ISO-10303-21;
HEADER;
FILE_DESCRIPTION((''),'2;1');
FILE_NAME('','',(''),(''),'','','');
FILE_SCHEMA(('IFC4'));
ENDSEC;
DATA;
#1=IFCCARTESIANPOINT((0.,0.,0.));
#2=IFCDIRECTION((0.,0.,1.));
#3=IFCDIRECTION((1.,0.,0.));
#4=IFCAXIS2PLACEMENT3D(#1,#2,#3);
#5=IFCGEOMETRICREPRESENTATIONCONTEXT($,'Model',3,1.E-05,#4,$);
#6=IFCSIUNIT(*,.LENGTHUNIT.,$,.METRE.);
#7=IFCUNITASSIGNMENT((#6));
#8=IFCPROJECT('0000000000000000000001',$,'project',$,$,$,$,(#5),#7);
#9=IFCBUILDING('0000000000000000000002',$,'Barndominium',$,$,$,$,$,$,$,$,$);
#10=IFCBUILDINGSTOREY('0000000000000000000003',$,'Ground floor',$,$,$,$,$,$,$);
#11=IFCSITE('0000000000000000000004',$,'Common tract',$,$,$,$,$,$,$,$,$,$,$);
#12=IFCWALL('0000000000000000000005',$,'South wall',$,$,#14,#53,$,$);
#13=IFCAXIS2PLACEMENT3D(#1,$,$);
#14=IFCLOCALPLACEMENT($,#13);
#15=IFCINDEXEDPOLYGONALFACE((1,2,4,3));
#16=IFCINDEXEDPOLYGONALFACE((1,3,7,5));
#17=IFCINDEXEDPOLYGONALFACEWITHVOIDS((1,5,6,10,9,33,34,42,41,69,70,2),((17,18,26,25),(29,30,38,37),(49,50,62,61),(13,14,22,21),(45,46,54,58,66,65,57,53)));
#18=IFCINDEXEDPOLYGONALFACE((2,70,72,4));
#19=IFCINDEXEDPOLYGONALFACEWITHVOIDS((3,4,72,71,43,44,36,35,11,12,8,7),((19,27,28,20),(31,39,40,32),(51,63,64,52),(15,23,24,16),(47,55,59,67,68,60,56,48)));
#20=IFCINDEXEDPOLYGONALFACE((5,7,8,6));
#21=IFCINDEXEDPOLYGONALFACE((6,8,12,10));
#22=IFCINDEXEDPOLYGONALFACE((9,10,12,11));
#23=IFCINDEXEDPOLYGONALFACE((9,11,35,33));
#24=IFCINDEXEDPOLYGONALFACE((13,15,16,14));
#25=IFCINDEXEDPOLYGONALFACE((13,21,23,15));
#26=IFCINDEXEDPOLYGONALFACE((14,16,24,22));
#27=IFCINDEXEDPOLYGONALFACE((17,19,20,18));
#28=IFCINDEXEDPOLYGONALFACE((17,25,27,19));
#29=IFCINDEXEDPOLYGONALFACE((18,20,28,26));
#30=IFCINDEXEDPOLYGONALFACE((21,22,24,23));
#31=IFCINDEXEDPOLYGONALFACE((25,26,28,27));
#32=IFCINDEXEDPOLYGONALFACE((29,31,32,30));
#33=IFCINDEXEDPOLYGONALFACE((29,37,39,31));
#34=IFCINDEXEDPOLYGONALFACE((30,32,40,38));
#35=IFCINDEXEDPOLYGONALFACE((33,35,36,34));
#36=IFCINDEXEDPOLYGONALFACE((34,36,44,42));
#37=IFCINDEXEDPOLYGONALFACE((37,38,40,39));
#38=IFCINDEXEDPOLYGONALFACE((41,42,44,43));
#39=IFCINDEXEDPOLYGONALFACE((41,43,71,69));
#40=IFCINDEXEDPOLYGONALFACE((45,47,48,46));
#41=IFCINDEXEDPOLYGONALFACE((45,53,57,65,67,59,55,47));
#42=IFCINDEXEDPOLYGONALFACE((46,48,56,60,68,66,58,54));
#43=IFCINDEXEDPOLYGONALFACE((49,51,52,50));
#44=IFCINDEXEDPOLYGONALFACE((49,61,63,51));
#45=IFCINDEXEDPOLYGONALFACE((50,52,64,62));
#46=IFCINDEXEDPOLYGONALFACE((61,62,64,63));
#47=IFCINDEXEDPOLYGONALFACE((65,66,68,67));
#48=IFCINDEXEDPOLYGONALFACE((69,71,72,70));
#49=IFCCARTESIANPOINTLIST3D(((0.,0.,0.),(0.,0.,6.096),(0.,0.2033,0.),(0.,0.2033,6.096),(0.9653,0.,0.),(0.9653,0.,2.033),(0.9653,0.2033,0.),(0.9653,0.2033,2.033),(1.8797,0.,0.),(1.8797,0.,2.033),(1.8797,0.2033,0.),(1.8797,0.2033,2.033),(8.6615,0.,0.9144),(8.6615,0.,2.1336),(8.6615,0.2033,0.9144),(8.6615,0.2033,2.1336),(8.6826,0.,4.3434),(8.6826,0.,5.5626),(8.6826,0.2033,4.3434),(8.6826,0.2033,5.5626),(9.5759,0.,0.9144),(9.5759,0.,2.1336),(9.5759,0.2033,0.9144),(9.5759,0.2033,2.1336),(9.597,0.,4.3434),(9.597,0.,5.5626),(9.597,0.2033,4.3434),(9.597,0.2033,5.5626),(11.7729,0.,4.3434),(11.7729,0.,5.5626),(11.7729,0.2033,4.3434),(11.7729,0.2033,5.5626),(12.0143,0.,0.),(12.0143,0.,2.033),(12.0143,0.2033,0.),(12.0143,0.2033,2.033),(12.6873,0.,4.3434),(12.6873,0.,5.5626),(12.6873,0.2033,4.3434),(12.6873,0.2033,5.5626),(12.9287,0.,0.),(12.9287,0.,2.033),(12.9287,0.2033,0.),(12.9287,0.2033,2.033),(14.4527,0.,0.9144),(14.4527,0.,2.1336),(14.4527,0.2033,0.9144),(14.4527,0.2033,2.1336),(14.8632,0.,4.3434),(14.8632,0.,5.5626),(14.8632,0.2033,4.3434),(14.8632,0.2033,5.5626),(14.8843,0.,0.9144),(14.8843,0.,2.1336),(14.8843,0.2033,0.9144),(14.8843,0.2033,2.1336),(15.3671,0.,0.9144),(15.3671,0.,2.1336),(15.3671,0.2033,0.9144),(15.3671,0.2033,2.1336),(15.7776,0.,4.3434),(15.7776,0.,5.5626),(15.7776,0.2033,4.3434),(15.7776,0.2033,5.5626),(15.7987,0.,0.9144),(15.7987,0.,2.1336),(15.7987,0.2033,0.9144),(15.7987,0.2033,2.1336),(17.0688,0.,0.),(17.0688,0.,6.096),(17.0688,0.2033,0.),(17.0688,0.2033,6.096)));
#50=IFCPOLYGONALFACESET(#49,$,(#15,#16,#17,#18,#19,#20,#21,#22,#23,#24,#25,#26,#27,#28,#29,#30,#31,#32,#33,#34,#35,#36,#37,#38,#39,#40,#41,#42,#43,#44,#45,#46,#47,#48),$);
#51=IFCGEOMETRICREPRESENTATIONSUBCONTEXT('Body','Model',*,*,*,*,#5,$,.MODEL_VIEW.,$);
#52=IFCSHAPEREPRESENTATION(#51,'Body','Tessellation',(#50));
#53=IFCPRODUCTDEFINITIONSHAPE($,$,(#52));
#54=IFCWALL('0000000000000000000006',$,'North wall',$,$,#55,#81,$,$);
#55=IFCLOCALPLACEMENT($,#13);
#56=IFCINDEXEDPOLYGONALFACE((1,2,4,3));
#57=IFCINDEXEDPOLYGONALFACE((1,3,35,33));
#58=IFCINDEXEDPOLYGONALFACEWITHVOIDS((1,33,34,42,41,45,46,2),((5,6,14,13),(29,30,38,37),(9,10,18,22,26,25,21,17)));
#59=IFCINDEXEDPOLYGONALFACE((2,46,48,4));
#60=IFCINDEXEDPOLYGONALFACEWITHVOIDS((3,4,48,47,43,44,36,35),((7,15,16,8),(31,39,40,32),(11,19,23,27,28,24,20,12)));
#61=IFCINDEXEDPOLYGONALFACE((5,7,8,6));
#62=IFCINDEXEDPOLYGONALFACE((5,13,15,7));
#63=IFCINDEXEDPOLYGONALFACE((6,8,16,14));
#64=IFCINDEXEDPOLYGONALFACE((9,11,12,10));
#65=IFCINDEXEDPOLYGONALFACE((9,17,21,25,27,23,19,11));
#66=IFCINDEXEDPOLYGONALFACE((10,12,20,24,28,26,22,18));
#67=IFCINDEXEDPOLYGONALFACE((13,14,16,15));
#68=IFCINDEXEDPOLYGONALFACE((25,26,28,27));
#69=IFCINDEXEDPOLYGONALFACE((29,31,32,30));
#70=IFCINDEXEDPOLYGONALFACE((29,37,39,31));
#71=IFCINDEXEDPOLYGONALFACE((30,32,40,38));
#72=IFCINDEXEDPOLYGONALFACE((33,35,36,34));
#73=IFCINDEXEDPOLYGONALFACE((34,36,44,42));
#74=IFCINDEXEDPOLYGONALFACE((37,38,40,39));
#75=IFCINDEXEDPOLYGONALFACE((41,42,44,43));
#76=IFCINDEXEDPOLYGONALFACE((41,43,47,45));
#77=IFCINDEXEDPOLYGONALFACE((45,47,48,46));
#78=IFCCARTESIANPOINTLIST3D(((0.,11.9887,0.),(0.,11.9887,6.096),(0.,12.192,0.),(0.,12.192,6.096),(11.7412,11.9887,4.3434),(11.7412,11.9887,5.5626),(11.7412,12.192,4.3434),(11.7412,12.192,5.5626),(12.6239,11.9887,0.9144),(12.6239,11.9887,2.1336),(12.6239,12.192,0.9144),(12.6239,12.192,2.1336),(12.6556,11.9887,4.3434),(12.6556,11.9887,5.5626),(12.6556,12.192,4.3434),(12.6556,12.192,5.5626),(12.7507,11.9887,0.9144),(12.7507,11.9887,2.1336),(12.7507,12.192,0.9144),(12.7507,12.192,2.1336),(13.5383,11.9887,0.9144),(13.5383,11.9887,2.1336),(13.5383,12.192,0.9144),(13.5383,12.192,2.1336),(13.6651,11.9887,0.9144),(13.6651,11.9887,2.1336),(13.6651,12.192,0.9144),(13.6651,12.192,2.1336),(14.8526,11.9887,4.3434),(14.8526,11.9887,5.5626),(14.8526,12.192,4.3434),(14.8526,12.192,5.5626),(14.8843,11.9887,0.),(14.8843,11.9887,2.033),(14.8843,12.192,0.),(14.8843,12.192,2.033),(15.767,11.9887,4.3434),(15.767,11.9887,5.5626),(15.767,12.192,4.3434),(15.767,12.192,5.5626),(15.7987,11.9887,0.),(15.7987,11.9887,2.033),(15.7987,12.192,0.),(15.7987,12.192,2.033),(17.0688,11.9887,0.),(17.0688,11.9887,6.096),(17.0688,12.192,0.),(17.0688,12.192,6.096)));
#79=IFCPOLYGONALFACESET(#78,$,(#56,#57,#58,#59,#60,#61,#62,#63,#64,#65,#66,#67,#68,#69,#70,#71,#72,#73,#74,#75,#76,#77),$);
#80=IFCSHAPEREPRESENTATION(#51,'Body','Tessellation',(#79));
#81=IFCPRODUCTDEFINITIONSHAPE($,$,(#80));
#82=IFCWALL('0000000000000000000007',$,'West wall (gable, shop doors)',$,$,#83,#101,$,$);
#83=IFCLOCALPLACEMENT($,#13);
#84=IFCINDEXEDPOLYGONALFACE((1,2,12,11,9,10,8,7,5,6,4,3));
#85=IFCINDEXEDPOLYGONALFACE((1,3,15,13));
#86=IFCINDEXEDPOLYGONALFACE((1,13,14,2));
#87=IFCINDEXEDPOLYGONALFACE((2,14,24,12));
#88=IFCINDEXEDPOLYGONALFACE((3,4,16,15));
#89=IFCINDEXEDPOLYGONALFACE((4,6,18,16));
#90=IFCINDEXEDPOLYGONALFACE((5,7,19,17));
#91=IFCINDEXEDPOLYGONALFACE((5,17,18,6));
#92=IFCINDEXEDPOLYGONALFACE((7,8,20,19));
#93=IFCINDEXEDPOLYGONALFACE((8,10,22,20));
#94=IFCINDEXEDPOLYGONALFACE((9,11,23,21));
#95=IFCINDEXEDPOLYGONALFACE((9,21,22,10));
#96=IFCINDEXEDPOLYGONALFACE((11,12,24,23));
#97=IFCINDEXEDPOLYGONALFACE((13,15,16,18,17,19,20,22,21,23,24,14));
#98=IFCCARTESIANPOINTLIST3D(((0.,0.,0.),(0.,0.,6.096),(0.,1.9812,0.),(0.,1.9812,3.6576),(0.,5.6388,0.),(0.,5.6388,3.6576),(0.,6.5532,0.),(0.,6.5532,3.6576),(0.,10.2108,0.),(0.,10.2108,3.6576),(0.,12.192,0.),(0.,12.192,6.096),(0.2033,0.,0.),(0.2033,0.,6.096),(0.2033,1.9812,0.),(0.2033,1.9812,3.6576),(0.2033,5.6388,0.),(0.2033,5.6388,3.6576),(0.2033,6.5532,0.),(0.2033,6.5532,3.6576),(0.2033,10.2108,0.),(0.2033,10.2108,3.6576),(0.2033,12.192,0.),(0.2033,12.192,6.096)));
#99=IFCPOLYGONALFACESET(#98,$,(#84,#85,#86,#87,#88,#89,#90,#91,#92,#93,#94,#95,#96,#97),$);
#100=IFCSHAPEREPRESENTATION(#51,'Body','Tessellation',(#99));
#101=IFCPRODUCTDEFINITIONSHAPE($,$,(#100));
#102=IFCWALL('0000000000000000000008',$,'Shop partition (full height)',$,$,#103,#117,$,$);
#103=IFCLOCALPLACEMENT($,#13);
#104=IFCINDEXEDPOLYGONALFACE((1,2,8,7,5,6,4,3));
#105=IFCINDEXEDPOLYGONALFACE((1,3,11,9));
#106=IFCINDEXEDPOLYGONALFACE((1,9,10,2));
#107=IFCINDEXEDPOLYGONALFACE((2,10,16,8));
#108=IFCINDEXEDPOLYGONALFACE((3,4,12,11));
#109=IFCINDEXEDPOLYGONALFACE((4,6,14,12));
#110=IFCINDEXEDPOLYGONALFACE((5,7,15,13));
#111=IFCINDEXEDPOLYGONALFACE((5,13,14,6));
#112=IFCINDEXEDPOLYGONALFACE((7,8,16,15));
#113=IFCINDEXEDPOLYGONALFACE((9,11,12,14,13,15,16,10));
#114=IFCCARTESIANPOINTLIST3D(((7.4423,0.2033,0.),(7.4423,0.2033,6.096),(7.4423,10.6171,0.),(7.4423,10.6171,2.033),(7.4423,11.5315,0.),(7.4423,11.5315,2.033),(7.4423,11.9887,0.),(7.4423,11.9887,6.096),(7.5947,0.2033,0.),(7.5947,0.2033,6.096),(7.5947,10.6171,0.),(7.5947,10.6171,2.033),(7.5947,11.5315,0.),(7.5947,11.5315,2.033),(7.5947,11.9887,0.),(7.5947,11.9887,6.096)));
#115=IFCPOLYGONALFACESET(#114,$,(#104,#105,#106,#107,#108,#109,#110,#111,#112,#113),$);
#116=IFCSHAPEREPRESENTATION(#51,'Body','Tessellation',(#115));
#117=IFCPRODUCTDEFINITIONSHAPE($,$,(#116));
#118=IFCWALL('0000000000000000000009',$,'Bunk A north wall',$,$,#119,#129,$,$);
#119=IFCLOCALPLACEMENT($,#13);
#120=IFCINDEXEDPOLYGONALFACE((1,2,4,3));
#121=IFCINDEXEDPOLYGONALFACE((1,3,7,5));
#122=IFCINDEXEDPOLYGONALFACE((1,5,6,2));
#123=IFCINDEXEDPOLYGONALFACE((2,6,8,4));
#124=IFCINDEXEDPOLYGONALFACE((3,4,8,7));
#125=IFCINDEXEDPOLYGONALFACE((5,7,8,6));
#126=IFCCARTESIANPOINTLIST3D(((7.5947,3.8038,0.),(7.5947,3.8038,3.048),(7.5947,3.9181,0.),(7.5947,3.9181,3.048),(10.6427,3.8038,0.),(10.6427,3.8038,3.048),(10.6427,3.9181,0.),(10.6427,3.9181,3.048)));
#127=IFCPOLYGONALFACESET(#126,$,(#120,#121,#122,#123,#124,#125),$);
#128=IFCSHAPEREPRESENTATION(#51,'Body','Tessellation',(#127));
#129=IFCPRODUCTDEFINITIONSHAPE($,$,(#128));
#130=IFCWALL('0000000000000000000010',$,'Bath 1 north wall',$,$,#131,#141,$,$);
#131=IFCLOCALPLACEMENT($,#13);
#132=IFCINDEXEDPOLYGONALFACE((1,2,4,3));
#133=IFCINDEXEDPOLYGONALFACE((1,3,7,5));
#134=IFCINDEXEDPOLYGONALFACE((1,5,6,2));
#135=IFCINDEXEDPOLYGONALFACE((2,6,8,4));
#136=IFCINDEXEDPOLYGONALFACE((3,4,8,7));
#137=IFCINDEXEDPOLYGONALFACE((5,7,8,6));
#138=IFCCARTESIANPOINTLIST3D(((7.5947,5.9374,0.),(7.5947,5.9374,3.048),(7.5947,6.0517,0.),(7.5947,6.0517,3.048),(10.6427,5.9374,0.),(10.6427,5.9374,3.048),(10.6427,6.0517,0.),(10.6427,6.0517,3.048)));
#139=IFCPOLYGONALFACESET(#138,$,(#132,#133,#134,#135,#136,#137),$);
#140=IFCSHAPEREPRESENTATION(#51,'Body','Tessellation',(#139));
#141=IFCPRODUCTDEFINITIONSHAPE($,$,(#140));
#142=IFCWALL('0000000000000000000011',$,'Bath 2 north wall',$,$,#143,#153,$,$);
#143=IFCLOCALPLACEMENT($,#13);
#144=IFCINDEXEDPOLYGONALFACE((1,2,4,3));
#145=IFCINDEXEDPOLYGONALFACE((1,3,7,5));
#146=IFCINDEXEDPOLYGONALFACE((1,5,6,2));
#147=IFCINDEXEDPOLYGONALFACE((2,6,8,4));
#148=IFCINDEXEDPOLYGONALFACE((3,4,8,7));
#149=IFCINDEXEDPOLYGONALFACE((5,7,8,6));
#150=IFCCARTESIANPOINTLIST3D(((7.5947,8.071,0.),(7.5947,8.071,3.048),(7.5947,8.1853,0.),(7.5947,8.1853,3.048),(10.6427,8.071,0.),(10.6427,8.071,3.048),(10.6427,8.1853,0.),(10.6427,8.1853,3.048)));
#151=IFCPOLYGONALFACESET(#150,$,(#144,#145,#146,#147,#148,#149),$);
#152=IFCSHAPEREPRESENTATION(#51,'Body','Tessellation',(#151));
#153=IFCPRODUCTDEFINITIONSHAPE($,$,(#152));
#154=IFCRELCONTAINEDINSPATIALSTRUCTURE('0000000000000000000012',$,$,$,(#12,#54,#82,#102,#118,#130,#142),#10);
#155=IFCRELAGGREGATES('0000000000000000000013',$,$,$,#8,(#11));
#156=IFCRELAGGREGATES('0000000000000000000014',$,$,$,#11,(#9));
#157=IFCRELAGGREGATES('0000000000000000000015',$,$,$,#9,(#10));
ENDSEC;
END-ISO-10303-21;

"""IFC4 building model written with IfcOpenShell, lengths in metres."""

from ifc_helpers import new_model, si_unit, frame, origin_with_axes, place, context, subcontext, project, spatial, indexed_curve, rectangle, outline, extrude, element, save


model = new_model("IFC4")

# Units and contexts
model_context = context("Model", 3, precision=1e-05, world=origin_with_axes())
body_context = subcontext(model_context, "Body", "Model", "MODEL_VIEW")
ifc_project = project(units=[si_unit("LENGTHUNIT", "METRE")], contexts=[model_context])

# Site, building, storey
site = spatial("IfcSite", under=ifc_project, Name="Common tract")
building = spatial("IfcBuilding", under=site, Name="Barndominium")
storey = spatial("IfcBuildingStorey", under=building, Name="Ground floor")

# Walls, openings
wall_1_placement = place(None, origin_with_axes())
wall_1 = element("IfcWall", 1, at=wall_1_placement, inside=storey, Name="South wall", context=body_context, shape_type="SweptSolid", body=[
    extrude(outline(indexed_curve([(0.0, 0.0), (0.0, 0.2033), (17.0688, 0.2033), (17.0688, 0.0), (0.0, 0.0)], self_intersect=False)), origin_with_axes(), (0.0, 0.0, 1.0), 6.096),
])
opening_1_placement = place(wall_1_placement, frame((1.4225, 0.1017, 0.0), z_axis=(0.0, 0.0, 1.0), x_axis=(1.0, 0.0, 0.0)))
element("IfcOpeningElement", 2, at=opening_1_placement, cuts=wall_1, context=body_context, shape_type="SweptSolid", body=[
    extrude(rectangle(XDim=0.9144, YDim=0.3033), origin_with_axes(), (0.0, 0.0, 1.0), 2.033),
])
opening_2_placement = place(wall_1_placement, frame((12.4715, 0.1017, 0.0), z_axis=(0.0, 0.0, 1.0), x_axis=(1.0, 0.0, 0.0)))
element("IfcOpeningElement", 3, at=opening_2_placement, cuts=wall_1, context=body_context, shape_type="SweptSolid", body=[
    extrude(rectangle(XDim=0.9144, YDim=0.3033), origin_with_axes(), (0.0, 0.0, 1.0), 2.033),
])
opening_3_placement = place(wall_1_placement, frame((14.9099, 0.1017, 0.9144), z_axis=(0.0, 0.0, 1.0), x_axis=(1.0, 0.0, 0.0)))
element("IfcOpeningElement", 4, at=opening_3_placement, cuts=wall_1, context=body_context, shape_type="SweptSolid", body=[
    extrude(rectangle(XDim=0.9144, YDim=0.3033), origin_with_axes(), (0.0, 0.0, 1.0), 1.2192),
])
opening_4_placement = place(wall_1_placement, frame((15.3415, 0.1017, 0.9144), z_axis=(0.0, 0.0, 1.0), x_axis=(1.0, 0.0, 0.0)))
element("IfcOpeningElement", 5, at=opening_4_placement, cuts=wall_1, context=body_context, shape_type="SweptSolid", body=[
    extrude(rectangle(XDim=0.9144, YDim=0.3033), origin_with_axes(), (0.0, 0.0, 1.0), 1.2192),
])
opening_5_placement = place(wall_1_placement, frame((9.1187, 0.1017, 0.9144), z_axis=(0.0, 0.0, 1.0), x_axis=(1.0, 0.0, 0.0)))
element("IfcOpeningElement", 6, at=opening_5_placement, cuts=wall_1, context=body_context, shape_type="SweptSolid", body=[
    extrude(rectangle(XDim=0.9144, YDim=0.3033), origin_with_axes(), (0.0, 0.0, 1.0), 1.2192),
])
opening_6_placement = place(wall_1_placement, frame((9.1398, 0.1017, 4.3434), z_axis=(0.0, 0.0, 1.0), x_axis=(1.0, 0.0, 0.0)))
element("IfcOpeningElement", 7, at=opening_6_placement, cuts=wall_1, context=body_context, shape_type="SweptSolid", body=[
    extrude(rectangle(XDim=0.9144, YDim=0.3033), origin_with_axes(), (0.0, 0.0, 1.0), 1.2192),
])
opening_7_placement = place(wall_1_placement, frame((12.2301, 0.1017, 4.3434), z_axis=(0.0, 0.0, 1.0), x_axis=(1.0, 0.0, 0.0)))
element("IfcOpeningElement", 8, at=opening_7_placement, cuts=wall_1, context=body_context, shape_type="SweptSolid", body=[
    extrude(rectangle(XDim=0.9144, YDim=0.3033), origin_with_axes(), (0.0, 0.0, 1.0), 1.2192),
])
opening_8_placement = place(wall_1_placement, frame((15.3204, 0.1017, 4.3434), z_axis=(0.0, 0.0, 1.0), x_axis=(1.0, 0.0, 0.0)))
element("IfcOpeningElement", 9, at=opening_8_placement, cuts=wall_1, context=body_context, shape_type="SweptSolid", body=[
    extrude(rectangle(XDim=0.9144, YDim=0.3033), origin_with_axes(), (0.0, 0.0, 1.0), 1.2192),
])
wall_2_placement = place(None, frame((0.0, 11.9887, 0.0), z_axis=(0.0, 0.0, 1.0), x_axis=(1.0, 0.0, 0.0)))
wall_2 = element("IfcWall", 10, at=wall_2_placement, inside=storey, Name="North wall", context=body_context, shape_type="SweptSolid", body=[
    extrude(outline(indexed_curve([(0.0, 0.0), (0.0, 0.2033), (17.0688, 0.2033), (17.0688, 0.0), (0.0, 0.0)], self_intersect=False)), origin_with_axes(), (0.0, 0.0, 1.0), 6.096),
])
opening_9_placement = place(wall_2_placement, frame((15.3415, 0.1017, 0.0), z_axis=(0.0, 0.0, 1.0), x_axis=(1.0, 0.0, 0.0)))
element("IfcOpeningElement", 11, at=opening_9_placement, cuts=wall_2, context=body_context, shape_type="SweptSolid", body=[
    extrude(rectangle(XDim=0.9144, YDim=0.3033), origin_with_axes(), (0.0, 0.0, 1.0), 2.033),
])
opening_10_placement = place(wall_2_placement, frame((13.0811, 0.1017, 0.9144), z_axis=(0.0, 0.0, 1.0), x_axis=(1.0, 0.0, 0.0)))
element("IfcOpeningElement", 12, at=opening_10_placement, cuts=wall_2, context=body_context, shape_type="SweptSolid", body=[
    extrude(rectangle(XDim=0.9144, YDim=0.3033), origin_with_axes(), (0.0, 0.0, 1.0), 1.2192),
])
opening_11_placement = place(wall_2_placement, frame((13.2079, 0.1017, 0.9144), z_axis=(0.0, 0.0, 1.0), x_axis=(1.0, 0.0, 0.0)))
element("IfcOpeningElement", 13, at=opening_11_placement, cuts=wall_2, context=body_context, shape_type="SweptSolid", body=[
    extrude(rectangle(XDim=0.9144, YDim=0.3033), origin_with_axes(), (0.0, 0.0, 1.0), 1.2192),
])
opening_12_placement = place(wall_2_placement, frame((12.1984, 0.1017, 4.3434), z_axis=(0.0, 0.0, 1.0), x_axis=(1.0, 0.0, 0.0)))
element("IfcOpeningElement", 14, at=opening_12_placement, cuts=wall_2, context=body_context, shape_type="SweptSolid", body=[
    extrude(rectangle(XDim=0.9144, YDim=0.3033), origin_with_axes(), (0.0, 0.0, 1.0), 1.2192),
])
opening_13_placement = place(wall_2_placement, frame((15.3098, 0.1017, 4.3434), z_axis=(0.0, 0.0, 1.0), x_axis=(1.0, 0.0, 0.0)))
element("IfcOpeningElement", 15, at=opening_13_placement, cuts=wall_2, context=body_context, shape_type="SweptSolid", body=[
    extrude(rectangle(XDim=0.9144, YDim=0.3033), origin_with_axes(), (0.0, 0.0, 1.0), 1.2192),
])
wall_3_placement = place(None, frame((0.2033, 0.0, 0.0), z_axis=(0.0, 0.0, 1.0), x_axis=(0.0, 1.0, 0.0)))
wall_3 = element("IfcWall", 16, at=wall_3_placement, inside=storey, Name="West wall (gable, shop doors)", context=body_context, shape_type="SweptSolid", body=[
    extrude(outline(indexed_curve([(0.0, 0.0), (0.0, 0.2033), (12.192, 0.2033), (12.192, 0.0), (0.0, 0.0)], self_intersect=False)), origin_with_axes(), (0.0, 0.0, 1.0), 6.096),
])
opening_14_placement = place(wall_3_placement, frame((3.81, 0.1017, 0.0), z_axis=(0.0, 0.0, 1.0), x_axis=(0.0, -1.0, 0.0)))
element("IfcOpeningElement", 17, at=opening_14_placement, cuts=wall_3, context=body_context, shape_type="SweptSolid", body=[
    extrude(rectangle(XDim=0.3033, YDim=3.6576), origin_with_axes(), (0.0, 0.0, 1.0), 3.6576),
])
opening_15_placement = place(wall_3_placement, frame((8.382, 0.1017, 0.0), z_axis=(0.0, 0.0, 1.0), x_axis=(0.0, -1.0, 0.0)))
element("IfcOpeningElement", 18, at=opening_15_placement, cuts=wall_3, context=body_context, shape_type="SweptSolid", body=[
    extrude(rectangle(XDim=0.3033, YDim=3.6576), origin_with_axes(), (0.0, 0.0, 1.0), 3.6576),
])

# Wall, opening
wall_4_placement = place(None, frame((7.5947, 0.2033, 0.0), z_axis=(0.0, 0.0, 1.0), x_axis=(0.0, 1.0, 0.0)))
wall_4 = element("IfcWall", 19, at=wall_4_placement, inside=storey, Name="Shop partition (full height)", context=body_context, shape_type="SweptSolid", body=[
    extrude(outline(indexed_curve([(0.0, 0.0), (0.0, 0.1524), (11.7854, 0.1524), (11.7854, 0.0), (0.0, 0.0)], self_intersect=False)), origin_with_axes(), (0.0, 0.0, 1.0), 6.096),
])
opening_16_placement = place(wall_4_placement, frame((10.871, 0.0762, 0.0), z_axis=(0.0, 0.0, 1.0), x_axis=(0.0, -1.0, 0.0)))
element("IfcOpeningElement", 20, at=opening_16_placement, cuts=wall_4, context=body_context, shape_type="SweptSolid", body=[
    extrude(rectangle(XDim=0.3033, YDim=0.9144), origin_with_axes(), (0.0, 0.0, 1.0), 2.033),
])

# Walls
for number, where, z_axis, x_axis, name in (
    (21, (7.5947, 3.8038, 0.0), (0.0, 0.0, 1.0), (1.0, 0.0, 0.0), "Bunk A north wall"),
    (22, (7.5947, 5.9374, 0.0), (0.0, 0.0, 1.0), (1.0, 0.0, 0.0), "Bath 1 north wall"),
    (23, (7.5947, 8.071, 0.0), (0.0, 0.0, 1.0), (1.0, 0.0, 0.0), "Bath 2 north wall"),
):
    element("IfcWall", number, at=place(None, frame(where, z_axis=z_axis, x_axis=x_axis)), inside=storey, Name=name, context=body_context, shape_type="SweptSolid", body=[
        extrude(outline(indexed_curve([(0.0, 0.0), (0.0, 0.1143), (3.048, 0.1143), (3.048, 0.0), (0.0, 0.0)], self_intersect=False)), origin_with_axes(), (0.0, 0.0, 1.0), 3.048),
    ])

save(model, "model.ifc")
